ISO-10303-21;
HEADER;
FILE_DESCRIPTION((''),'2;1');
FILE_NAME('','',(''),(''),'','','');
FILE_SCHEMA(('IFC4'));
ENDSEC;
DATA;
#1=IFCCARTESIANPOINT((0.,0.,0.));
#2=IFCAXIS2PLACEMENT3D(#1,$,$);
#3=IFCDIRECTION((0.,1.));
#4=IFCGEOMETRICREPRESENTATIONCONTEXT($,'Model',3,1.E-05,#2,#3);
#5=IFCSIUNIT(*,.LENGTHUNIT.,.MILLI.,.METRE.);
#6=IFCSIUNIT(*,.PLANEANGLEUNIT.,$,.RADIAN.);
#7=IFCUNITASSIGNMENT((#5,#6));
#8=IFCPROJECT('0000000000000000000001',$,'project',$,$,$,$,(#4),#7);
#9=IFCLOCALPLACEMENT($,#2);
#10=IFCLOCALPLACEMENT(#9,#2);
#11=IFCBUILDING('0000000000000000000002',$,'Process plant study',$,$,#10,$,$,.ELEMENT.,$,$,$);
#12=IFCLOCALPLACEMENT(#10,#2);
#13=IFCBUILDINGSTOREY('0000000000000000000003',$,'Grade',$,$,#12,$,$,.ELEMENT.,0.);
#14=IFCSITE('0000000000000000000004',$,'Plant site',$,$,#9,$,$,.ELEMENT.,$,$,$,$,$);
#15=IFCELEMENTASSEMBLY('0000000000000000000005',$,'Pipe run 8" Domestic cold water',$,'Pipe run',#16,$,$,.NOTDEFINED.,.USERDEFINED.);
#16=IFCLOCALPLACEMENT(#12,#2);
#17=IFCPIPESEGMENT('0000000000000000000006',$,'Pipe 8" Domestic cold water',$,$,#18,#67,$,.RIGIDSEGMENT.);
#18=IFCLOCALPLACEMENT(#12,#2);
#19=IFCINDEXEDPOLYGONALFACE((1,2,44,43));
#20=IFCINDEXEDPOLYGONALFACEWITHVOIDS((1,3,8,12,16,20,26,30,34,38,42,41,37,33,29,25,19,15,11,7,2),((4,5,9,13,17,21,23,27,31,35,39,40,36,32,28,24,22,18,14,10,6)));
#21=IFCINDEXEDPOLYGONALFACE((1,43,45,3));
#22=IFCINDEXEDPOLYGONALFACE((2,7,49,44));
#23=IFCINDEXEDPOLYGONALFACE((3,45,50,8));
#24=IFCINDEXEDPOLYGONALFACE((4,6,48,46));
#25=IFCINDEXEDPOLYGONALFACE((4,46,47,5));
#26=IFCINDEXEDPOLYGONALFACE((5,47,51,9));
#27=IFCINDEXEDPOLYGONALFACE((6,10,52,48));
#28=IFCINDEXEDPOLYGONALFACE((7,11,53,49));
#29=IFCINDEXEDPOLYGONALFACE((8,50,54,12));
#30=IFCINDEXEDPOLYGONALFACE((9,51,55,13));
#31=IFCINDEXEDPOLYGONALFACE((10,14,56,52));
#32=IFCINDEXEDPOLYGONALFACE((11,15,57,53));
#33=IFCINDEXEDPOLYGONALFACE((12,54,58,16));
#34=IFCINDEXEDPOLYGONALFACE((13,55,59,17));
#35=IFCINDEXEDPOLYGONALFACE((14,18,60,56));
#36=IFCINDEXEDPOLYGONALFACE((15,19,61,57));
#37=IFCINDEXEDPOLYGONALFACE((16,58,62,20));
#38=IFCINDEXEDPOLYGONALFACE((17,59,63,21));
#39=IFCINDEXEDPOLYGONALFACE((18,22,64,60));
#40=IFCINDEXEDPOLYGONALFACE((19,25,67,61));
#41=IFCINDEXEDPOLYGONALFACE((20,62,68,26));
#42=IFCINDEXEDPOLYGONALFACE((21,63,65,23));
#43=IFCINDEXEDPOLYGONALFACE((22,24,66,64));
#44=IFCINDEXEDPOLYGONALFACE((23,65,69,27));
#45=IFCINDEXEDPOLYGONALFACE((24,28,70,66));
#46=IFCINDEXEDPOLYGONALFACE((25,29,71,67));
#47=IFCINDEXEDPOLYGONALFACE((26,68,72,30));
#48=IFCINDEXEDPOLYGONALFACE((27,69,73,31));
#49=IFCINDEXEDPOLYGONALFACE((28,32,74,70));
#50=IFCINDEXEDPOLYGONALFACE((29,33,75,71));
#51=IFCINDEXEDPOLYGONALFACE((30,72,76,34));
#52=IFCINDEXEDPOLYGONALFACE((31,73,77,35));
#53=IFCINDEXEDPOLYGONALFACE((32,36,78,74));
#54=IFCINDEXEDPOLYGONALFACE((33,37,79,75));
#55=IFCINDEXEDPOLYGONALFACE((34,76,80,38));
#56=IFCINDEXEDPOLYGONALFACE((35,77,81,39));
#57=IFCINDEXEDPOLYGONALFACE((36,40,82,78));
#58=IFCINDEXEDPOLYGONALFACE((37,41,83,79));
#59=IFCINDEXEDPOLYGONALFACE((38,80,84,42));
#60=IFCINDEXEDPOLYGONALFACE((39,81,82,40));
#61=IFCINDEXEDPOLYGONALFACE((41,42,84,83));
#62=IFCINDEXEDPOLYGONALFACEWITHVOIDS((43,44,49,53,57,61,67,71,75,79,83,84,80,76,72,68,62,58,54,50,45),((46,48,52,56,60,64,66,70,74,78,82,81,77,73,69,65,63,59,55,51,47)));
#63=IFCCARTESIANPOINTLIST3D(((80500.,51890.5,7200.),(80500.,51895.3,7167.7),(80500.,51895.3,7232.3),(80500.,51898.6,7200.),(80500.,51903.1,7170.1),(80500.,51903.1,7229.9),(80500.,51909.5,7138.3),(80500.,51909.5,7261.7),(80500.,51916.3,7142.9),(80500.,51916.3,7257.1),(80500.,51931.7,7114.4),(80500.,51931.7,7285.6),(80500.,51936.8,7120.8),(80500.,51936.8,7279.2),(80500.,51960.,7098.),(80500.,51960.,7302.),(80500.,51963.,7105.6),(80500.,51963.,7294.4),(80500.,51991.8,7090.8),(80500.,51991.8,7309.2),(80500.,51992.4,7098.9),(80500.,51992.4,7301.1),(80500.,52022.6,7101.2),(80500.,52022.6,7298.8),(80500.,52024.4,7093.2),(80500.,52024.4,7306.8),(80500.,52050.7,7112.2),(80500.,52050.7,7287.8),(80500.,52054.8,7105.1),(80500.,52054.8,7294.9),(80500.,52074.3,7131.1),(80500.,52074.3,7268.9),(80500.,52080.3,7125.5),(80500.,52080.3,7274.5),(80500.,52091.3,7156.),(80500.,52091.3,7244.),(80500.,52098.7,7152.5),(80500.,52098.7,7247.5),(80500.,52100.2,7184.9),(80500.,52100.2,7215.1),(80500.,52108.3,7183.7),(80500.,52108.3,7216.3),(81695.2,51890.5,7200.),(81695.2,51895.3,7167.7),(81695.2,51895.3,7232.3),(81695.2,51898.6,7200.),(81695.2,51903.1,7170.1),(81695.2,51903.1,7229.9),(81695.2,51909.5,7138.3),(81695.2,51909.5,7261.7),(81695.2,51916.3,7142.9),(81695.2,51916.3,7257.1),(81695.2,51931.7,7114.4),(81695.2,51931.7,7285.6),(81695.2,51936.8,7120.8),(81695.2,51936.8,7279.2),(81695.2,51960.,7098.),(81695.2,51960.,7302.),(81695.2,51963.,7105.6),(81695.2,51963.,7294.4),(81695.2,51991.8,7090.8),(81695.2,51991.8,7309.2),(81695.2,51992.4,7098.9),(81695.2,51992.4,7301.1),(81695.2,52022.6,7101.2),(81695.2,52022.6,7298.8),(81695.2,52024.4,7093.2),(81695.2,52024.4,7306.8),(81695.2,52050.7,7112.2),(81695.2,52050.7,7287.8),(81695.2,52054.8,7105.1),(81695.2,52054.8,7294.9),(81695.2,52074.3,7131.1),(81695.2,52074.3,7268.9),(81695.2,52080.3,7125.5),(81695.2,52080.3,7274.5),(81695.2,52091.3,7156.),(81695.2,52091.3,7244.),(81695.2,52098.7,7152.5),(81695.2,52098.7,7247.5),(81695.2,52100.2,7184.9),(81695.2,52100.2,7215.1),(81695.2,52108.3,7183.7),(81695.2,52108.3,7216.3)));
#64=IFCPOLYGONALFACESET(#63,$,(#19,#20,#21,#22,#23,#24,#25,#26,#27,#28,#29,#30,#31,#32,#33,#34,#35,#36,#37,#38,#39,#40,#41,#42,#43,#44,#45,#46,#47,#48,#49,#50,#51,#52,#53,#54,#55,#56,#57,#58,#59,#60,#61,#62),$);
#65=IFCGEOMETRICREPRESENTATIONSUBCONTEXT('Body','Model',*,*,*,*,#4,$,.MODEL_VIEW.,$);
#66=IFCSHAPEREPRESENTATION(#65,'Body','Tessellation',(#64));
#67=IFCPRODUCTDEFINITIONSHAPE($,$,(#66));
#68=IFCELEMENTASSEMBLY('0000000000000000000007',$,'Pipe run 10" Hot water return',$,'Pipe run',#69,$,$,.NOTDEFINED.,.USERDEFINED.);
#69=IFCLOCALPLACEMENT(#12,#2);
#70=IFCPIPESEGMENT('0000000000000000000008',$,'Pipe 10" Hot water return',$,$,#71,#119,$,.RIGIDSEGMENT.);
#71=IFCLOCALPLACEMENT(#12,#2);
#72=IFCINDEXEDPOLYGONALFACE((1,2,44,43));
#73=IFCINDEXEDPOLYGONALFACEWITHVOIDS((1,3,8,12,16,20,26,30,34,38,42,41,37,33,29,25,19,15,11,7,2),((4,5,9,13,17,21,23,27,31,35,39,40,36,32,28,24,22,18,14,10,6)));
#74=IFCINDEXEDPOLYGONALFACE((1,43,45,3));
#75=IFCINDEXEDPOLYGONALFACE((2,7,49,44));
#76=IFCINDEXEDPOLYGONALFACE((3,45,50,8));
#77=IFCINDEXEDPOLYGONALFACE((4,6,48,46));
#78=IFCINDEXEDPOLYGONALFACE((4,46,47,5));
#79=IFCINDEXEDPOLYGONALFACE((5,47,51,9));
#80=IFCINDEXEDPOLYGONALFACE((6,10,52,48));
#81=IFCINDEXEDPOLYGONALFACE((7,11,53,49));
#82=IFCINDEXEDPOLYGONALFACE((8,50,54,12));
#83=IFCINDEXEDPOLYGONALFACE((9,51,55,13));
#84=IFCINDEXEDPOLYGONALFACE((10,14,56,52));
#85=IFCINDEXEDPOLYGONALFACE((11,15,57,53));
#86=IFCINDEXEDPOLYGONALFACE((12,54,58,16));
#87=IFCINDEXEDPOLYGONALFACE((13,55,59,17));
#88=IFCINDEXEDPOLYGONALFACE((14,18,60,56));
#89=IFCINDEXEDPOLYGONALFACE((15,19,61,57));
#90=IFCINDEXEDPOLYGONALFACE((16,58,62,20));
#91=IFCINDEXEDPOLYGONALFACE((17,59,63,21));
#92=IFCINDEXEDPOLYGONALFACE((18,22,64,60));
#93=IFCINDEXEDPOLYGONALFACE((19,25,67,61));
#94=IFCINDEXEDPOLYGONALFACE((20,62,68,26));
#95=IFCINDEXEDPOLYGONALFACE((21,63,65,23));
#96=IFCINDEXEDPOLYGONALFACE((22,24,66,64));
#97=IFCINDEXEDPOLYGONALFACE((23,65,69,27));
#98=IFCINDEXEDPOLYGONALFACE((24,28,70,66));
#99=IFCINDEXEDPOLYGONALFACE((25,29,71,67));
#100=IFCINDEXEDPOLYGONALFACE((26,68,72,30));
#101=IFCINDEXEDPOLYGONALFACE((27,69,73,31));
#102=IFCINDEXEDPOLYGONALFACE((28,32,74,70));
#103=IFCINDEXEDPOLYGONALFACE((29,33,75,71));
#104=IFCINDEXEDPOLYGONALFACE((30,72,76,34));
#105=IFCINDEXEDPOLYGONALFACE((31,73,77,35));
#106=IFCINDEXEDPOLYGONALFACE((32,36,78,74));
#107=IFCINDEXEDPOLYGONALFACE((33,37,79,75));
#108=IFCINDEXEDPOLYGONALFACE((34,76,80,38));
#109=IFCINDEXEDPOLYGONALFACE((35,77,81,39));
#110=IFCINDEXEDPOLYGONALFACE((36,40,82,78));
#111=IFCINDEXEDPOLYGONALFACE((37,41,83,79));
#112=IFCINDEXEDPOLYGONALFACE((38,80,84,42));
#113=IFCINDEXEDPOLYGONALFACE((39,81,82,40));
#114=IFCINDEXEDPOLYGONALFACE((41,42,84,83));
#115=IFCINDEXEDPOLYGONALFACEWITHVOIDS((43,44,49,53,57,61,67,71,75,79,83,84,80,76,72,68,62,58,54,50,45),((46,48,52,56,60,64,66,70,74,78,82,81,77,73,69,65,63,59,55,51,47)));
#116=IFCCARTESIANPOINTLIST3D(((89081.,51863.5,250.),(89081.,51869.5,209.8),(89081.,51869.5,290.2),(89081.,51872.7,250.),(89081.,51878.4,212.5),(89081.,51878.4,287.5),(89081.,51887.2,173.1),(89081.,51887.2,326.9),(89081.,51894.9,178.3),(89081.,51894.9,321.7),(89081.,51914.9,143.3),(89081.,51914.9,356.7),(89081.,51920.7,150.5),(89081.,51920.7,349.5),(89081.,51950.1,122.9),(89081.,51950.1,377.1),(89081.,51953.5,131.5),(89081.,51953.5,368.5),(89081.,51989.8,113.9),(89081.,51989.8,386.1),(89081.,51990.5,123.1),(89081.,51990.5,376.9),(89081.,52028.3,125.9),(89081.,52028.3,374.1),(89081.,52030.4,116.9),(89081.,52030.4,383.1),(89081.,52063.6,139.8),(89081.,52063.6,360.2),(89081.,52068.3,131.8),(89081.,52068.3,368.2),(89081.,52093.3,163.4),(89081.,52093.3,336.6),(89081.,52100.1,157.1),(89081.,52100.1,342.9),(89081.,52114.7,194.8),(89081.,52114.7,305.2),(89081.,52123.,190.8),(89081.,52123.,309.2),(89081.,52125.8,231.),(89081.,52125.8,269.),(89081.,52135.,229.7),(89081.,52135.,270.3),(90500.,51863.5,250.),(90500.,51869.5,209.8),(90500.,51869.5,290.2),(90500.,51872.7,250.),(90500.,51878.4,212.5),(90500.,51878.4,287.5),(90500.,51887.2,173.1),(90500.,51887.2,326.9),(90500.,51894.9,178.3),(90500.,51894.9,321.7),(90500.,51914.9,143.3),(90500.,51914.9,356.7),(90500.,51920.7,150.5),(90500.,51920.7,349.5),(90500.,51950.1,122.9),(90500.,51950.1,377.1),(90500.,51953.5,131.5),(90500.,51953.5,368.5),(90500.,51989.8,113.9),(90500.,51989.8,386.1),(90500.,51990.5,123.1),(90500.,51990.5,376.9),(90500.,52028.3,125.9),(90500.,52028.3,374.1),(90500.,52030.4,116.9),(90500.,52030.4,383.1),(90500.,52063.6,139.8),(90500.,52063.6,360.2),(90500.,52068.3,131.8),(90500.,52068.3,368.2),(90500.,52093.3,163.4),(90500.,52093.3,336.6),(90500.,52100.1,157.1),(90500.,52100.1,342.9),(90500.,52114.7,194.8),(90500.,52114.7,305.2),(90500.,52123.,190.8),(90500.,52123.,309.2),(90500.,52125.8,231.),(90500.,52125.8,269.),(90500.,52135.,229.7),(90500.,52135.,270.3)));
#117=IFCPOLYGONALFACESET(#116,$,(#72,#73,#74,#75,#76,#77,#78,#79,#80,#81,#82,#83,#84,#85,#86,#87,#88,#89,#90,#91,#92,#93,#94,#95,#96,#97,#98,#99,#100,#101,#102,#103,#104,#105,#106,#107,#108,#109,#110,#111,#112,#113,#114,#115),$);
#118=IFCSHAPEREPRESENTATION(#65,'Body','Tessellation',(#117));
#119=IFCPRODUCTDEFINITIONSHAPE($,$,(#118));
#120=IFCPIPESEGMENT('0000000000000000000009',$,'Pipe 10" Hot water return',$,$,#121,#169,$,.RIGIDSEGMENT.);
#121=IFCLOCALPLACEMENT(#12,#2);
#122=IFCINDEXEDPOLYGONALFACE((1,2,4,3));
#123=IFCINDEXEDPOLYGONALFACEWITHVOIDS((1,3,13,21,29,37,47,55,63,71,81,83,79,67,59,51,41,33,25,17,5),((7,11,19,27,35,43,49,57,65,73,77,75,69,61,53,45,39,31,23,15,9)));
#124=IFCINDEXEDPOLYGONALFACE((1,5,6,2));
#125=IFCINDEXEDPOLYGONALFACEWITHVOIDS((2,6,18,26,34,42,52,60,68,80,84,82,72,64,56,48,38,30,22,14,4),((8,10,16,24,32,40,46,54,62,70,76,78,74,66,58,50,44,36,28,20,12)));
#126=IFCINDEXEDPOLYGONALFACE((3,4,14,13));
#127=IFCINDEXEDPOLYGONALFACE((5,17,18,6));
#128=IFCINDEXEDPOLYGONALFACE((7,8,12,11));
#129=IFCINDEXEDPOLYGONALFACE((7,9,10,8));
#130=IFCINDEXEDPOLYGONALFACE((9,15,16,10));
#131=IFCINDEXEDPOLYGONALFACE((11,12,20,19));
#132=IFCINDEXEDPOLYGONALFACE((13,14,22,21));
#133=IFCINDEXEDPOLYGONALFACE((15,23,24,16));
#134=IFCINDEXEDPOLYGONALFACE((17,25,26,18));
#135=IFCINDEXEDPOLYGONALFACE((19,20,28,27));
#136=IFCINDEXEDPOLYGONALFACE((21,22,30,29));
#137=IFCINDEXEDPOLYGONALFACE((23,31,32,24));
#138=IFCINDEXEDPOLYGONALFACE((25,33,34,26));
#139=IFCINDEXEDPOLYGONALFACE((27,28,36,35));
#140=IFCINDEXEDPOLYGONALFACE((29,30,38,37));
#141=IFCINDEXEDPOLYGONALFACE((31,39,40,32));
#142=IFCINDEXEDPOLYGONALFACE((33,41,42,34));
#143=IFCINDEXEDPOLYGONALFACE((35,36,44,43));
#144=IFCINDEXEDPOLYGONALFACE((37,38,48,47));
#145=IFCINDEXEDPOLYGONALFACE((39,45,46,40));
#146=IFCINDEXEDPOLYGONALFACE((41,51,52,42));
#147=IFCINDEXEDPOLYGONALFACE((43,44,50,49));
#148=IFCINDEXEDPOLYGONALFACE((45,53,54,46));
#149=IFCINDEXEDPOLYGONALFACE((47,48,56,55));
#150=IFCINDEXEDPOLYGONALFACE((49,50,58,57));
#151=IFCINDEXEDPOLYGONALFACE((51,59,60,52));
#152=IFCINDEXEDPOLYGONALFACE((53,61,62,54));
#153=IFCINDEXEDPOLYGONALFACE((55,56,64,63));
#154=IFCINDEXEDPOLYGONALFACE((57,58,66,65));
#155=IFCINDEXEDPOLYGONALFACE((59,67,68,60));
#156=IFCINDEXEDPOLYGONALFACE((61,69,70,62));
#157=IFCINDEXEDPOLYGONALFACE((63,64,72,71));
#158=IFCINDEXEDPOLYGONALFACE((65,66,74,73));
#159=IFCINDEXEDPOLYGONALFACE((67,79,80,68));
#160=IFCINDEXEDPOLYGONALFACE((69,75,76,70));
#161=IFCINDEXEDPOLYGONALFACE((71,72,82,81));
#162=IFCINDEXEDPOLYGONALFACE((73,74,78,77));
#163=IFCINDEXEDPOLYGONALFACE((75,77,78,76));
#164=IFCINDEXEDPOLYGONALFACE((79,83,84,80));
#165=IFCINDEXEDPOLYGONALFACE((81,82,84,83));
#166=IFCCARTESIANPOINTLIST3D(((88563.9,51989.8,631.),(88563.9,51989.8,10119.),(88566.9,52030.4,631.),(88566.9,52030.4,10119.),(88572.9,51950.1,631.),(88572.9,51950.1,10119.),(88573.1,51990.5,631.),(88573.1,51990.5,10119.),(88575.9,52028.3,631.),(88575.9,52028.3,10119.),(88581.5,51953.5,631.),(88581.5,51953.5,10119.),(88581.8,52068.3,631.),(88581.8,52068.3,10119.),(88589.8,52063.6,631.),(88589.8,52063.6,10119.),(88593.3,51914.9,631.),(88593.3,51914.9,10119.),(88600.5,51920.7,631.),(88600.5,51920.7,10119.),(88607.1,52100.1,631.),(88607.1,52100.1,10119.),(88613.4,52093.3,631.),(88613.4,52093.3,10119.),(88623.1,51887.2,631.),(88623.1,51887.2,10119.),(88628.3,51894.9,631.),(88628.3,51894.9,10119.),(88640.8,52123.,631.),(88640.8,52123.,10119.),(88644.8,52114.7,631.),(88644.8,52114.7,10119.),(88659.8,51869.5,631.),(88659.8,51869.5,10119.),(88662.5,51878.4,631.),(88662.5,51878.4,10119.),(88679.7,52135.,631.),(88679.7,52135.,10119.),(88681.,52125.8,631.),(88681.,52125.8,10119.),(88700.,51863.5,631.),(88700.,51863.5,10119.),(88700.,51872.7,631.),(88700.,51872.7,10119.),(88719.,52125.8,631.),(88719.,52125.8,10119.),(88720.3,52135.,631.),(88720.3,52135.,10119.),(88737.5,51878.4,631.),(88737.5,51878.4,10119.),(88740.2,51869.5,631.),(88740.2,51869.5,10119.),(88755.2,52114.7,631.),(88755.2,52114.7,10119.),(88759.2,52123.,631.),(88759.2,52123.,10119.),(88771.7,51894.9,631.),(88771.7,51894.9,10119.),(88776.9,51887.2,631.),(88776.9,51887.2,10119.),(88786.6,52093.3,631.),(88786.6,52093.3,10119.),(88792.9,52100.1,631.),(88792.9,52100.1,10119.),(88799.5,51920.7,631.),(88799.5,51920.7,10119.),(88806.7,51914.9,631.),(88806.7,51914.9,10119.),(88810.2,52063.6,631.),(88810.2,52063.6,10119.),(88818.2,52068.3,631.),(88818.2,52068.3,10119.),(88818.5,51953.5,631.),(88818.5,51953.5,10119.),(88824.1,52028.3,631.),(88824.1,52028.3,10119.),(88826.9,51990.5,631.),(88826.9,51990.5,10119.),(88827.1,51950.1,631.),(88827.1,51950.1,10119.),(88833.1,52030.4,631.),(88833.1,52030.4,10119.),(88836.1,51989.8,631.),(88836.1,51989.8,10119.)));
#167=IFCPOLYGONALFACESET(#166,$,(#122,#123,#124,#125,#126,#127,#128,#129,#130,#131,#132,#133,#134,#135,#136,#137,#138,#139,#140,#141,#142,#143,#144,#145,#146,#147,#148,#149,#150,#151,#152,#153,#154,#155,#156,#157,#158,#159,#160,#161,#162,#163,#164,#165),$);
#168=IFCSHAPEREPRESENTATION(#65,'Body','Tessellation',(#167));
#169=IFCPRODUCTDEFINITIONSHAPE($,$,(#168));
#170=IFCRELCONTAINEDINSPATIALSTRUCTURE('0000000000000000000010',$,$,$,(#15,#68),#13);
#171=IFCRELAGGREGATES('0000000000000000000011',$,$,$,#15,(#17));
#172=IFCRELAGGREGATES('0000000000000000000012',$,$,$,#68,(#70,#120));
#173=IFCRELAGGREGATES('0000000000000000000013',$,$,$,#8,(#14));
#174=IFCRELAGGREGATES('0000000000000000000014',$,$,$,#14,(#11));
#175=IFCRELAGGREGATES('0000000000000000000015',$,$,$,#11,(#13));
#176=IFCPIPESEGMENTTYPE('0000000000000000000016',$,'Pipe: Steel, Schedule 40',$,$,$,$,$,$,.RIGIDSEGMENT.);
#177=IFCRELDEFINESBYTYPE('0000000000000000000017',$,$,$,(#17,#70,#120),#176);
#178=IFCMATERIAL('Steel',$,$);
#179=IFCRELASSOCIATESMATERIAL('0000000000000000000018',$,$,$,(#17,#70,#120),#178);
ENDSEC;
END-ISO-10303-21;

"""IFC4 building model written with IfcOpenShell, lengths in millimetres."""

from ifc_helpers import new_model, si_unit, direction, frame, origin, origin_with_axes, origin_2d, place, context, subcontext, project, spatial, hollow_circle, extrude, material, type_object, element, aggregate, save


model = new_model("IFC4")

# Units and contexts
model_context = context("Model", 3, precision=1e-05, world=origin(), true_north=direction((0.0, 1.0)))
body_context = subcontext(model_context, "Body", "Model", "MODEL_VIEW")
ifc_project = project(units=[si_unit("LENGTHUNIT", "METRE", prefix="MILLI"), si_unit("PLANEANGLEUNIT", "RADIAN")], contexts=[model_context])

# Site, building, storey
site_placement = place(None, origin())
site = spatial("IfcSite", under=ifc_project, at=site_placement, Name="Plant site", CompositionType="ELEMENT")
building_placement = place(site_placement, origin())
building = spatial("IfcBuilding", under=site, at=building_placement, Name="Process plant study", CompositionType="ELEMENT")
storey_placement = place(building_placement, origin())
storey = spatial("IfcBuildingStorey", under=building, at=storey_placement, Name="Grade", CompositionType="ELEMENT", Elevation=0.0)

# Shared definitions
ifc_material = material(Name="Steel")
pipe_segment_type = type_object("IfcPipeSegmentType", Name="Pipe: Steel, Schedule 40", PredefinedType="RIGIDSEGMENT")

# Element assemblies, pipe segments
assembly_1_placement = place(storey_placement, origin_with_axes())
assembly_1 = element("IfcElementAssembly", 1, at=assembly_1_placement, inside=storey, Name="Pipe run 8\" Domestic cold water", ObjectType="Pipe run", AssemblyPlace="NOTDEFINED", PredefinedType="USERDEFINED")
pipe_segment_1_placement = place(storey_placement, origin_with_axes())
pipe_segment_1 = element("IfcPipeSegment", 2, at=pipe_segment_1_placement, type_object=pipe_segment_type, material=ifc_material, Name="Pipe 8\" Domestic cold water", PredefinedType="RIGIDSEGMENT", context=body_context, shape_type="SweptSolid", body=[
    extrude(hollow_circle(Radius=109.5, WallThickness=8.2, at=origin_2d()), frame((81695.2, 52000.0, 7200.0), z_axis=(-1.0, 0.0, 0.0), x_axis=(0.0, -1.0, 0.0)), (0.0, 0.0, 1.0), 1195.2),
])
assembly_2_placement = place(storey_placement, origin_with_axes())
assembly_2 = element("IfcElementAssembly", 3, at=assembly_2_placement, inside=storey, Name="Pipe run 10\" Hot water return", ObjectType="Pipe run", AssemblyPlace="NOTDEFINED", PredefinedType="USERDEFINED")
pipe_segment_2_placement = place(storey_placement, origin_with_axes())
pipe_segment_2 = element("IfcPipeSegment", 4, at=pipe_segment_2_placement, type_object=pipe_segment_type, material=ifc_material, Name="Pipe 10\" Hot water return", PredefinedType="RIGIDSEGMENT", context=body_context, shape_type="SweptSolid", body=[
    extrude(hollow_circle(Radius=136.5, WallThickness=9.3, at=origin_2d()), frame((90500.0, 52000.0, 250.0), z_axis=(-1.0, 0.0, 0.0), x_axis=(0.0, -1.0, 0.0)), (0.0, 0.0, 1.0), 1419.0),
])
pipe_segment_3_placement = place(storey_placement, origin_with_axes())
pipe_segment_3 = element("IfcPipeSegment", 5, at=pipe_segment_3_placement, type_object=pipe_segment_type, material=ifc_material, Name="Pipe 10\" Hot water return", PredefinedType="RIGIDSEGMENT", context=body_context, shape_type="SweptSolid", body=[
    extrude(hollow_circle(Radius=136.5, WallThickness=9.3, at=origin_2d()), frame((88700.0, 52000.0, 631.0), z_axis=(0.0, 0.0, 1.0), x_axis=(0.0, -1.0, 0.0)), (0.0, 0.0, 1.0), 9488.0),
])

aggregate(assembly_1, [pipe_segment_1])
aggregate(assembly_2, [pipe_segment_2, pipe_segment_3])

save(model, "model.ifc")
